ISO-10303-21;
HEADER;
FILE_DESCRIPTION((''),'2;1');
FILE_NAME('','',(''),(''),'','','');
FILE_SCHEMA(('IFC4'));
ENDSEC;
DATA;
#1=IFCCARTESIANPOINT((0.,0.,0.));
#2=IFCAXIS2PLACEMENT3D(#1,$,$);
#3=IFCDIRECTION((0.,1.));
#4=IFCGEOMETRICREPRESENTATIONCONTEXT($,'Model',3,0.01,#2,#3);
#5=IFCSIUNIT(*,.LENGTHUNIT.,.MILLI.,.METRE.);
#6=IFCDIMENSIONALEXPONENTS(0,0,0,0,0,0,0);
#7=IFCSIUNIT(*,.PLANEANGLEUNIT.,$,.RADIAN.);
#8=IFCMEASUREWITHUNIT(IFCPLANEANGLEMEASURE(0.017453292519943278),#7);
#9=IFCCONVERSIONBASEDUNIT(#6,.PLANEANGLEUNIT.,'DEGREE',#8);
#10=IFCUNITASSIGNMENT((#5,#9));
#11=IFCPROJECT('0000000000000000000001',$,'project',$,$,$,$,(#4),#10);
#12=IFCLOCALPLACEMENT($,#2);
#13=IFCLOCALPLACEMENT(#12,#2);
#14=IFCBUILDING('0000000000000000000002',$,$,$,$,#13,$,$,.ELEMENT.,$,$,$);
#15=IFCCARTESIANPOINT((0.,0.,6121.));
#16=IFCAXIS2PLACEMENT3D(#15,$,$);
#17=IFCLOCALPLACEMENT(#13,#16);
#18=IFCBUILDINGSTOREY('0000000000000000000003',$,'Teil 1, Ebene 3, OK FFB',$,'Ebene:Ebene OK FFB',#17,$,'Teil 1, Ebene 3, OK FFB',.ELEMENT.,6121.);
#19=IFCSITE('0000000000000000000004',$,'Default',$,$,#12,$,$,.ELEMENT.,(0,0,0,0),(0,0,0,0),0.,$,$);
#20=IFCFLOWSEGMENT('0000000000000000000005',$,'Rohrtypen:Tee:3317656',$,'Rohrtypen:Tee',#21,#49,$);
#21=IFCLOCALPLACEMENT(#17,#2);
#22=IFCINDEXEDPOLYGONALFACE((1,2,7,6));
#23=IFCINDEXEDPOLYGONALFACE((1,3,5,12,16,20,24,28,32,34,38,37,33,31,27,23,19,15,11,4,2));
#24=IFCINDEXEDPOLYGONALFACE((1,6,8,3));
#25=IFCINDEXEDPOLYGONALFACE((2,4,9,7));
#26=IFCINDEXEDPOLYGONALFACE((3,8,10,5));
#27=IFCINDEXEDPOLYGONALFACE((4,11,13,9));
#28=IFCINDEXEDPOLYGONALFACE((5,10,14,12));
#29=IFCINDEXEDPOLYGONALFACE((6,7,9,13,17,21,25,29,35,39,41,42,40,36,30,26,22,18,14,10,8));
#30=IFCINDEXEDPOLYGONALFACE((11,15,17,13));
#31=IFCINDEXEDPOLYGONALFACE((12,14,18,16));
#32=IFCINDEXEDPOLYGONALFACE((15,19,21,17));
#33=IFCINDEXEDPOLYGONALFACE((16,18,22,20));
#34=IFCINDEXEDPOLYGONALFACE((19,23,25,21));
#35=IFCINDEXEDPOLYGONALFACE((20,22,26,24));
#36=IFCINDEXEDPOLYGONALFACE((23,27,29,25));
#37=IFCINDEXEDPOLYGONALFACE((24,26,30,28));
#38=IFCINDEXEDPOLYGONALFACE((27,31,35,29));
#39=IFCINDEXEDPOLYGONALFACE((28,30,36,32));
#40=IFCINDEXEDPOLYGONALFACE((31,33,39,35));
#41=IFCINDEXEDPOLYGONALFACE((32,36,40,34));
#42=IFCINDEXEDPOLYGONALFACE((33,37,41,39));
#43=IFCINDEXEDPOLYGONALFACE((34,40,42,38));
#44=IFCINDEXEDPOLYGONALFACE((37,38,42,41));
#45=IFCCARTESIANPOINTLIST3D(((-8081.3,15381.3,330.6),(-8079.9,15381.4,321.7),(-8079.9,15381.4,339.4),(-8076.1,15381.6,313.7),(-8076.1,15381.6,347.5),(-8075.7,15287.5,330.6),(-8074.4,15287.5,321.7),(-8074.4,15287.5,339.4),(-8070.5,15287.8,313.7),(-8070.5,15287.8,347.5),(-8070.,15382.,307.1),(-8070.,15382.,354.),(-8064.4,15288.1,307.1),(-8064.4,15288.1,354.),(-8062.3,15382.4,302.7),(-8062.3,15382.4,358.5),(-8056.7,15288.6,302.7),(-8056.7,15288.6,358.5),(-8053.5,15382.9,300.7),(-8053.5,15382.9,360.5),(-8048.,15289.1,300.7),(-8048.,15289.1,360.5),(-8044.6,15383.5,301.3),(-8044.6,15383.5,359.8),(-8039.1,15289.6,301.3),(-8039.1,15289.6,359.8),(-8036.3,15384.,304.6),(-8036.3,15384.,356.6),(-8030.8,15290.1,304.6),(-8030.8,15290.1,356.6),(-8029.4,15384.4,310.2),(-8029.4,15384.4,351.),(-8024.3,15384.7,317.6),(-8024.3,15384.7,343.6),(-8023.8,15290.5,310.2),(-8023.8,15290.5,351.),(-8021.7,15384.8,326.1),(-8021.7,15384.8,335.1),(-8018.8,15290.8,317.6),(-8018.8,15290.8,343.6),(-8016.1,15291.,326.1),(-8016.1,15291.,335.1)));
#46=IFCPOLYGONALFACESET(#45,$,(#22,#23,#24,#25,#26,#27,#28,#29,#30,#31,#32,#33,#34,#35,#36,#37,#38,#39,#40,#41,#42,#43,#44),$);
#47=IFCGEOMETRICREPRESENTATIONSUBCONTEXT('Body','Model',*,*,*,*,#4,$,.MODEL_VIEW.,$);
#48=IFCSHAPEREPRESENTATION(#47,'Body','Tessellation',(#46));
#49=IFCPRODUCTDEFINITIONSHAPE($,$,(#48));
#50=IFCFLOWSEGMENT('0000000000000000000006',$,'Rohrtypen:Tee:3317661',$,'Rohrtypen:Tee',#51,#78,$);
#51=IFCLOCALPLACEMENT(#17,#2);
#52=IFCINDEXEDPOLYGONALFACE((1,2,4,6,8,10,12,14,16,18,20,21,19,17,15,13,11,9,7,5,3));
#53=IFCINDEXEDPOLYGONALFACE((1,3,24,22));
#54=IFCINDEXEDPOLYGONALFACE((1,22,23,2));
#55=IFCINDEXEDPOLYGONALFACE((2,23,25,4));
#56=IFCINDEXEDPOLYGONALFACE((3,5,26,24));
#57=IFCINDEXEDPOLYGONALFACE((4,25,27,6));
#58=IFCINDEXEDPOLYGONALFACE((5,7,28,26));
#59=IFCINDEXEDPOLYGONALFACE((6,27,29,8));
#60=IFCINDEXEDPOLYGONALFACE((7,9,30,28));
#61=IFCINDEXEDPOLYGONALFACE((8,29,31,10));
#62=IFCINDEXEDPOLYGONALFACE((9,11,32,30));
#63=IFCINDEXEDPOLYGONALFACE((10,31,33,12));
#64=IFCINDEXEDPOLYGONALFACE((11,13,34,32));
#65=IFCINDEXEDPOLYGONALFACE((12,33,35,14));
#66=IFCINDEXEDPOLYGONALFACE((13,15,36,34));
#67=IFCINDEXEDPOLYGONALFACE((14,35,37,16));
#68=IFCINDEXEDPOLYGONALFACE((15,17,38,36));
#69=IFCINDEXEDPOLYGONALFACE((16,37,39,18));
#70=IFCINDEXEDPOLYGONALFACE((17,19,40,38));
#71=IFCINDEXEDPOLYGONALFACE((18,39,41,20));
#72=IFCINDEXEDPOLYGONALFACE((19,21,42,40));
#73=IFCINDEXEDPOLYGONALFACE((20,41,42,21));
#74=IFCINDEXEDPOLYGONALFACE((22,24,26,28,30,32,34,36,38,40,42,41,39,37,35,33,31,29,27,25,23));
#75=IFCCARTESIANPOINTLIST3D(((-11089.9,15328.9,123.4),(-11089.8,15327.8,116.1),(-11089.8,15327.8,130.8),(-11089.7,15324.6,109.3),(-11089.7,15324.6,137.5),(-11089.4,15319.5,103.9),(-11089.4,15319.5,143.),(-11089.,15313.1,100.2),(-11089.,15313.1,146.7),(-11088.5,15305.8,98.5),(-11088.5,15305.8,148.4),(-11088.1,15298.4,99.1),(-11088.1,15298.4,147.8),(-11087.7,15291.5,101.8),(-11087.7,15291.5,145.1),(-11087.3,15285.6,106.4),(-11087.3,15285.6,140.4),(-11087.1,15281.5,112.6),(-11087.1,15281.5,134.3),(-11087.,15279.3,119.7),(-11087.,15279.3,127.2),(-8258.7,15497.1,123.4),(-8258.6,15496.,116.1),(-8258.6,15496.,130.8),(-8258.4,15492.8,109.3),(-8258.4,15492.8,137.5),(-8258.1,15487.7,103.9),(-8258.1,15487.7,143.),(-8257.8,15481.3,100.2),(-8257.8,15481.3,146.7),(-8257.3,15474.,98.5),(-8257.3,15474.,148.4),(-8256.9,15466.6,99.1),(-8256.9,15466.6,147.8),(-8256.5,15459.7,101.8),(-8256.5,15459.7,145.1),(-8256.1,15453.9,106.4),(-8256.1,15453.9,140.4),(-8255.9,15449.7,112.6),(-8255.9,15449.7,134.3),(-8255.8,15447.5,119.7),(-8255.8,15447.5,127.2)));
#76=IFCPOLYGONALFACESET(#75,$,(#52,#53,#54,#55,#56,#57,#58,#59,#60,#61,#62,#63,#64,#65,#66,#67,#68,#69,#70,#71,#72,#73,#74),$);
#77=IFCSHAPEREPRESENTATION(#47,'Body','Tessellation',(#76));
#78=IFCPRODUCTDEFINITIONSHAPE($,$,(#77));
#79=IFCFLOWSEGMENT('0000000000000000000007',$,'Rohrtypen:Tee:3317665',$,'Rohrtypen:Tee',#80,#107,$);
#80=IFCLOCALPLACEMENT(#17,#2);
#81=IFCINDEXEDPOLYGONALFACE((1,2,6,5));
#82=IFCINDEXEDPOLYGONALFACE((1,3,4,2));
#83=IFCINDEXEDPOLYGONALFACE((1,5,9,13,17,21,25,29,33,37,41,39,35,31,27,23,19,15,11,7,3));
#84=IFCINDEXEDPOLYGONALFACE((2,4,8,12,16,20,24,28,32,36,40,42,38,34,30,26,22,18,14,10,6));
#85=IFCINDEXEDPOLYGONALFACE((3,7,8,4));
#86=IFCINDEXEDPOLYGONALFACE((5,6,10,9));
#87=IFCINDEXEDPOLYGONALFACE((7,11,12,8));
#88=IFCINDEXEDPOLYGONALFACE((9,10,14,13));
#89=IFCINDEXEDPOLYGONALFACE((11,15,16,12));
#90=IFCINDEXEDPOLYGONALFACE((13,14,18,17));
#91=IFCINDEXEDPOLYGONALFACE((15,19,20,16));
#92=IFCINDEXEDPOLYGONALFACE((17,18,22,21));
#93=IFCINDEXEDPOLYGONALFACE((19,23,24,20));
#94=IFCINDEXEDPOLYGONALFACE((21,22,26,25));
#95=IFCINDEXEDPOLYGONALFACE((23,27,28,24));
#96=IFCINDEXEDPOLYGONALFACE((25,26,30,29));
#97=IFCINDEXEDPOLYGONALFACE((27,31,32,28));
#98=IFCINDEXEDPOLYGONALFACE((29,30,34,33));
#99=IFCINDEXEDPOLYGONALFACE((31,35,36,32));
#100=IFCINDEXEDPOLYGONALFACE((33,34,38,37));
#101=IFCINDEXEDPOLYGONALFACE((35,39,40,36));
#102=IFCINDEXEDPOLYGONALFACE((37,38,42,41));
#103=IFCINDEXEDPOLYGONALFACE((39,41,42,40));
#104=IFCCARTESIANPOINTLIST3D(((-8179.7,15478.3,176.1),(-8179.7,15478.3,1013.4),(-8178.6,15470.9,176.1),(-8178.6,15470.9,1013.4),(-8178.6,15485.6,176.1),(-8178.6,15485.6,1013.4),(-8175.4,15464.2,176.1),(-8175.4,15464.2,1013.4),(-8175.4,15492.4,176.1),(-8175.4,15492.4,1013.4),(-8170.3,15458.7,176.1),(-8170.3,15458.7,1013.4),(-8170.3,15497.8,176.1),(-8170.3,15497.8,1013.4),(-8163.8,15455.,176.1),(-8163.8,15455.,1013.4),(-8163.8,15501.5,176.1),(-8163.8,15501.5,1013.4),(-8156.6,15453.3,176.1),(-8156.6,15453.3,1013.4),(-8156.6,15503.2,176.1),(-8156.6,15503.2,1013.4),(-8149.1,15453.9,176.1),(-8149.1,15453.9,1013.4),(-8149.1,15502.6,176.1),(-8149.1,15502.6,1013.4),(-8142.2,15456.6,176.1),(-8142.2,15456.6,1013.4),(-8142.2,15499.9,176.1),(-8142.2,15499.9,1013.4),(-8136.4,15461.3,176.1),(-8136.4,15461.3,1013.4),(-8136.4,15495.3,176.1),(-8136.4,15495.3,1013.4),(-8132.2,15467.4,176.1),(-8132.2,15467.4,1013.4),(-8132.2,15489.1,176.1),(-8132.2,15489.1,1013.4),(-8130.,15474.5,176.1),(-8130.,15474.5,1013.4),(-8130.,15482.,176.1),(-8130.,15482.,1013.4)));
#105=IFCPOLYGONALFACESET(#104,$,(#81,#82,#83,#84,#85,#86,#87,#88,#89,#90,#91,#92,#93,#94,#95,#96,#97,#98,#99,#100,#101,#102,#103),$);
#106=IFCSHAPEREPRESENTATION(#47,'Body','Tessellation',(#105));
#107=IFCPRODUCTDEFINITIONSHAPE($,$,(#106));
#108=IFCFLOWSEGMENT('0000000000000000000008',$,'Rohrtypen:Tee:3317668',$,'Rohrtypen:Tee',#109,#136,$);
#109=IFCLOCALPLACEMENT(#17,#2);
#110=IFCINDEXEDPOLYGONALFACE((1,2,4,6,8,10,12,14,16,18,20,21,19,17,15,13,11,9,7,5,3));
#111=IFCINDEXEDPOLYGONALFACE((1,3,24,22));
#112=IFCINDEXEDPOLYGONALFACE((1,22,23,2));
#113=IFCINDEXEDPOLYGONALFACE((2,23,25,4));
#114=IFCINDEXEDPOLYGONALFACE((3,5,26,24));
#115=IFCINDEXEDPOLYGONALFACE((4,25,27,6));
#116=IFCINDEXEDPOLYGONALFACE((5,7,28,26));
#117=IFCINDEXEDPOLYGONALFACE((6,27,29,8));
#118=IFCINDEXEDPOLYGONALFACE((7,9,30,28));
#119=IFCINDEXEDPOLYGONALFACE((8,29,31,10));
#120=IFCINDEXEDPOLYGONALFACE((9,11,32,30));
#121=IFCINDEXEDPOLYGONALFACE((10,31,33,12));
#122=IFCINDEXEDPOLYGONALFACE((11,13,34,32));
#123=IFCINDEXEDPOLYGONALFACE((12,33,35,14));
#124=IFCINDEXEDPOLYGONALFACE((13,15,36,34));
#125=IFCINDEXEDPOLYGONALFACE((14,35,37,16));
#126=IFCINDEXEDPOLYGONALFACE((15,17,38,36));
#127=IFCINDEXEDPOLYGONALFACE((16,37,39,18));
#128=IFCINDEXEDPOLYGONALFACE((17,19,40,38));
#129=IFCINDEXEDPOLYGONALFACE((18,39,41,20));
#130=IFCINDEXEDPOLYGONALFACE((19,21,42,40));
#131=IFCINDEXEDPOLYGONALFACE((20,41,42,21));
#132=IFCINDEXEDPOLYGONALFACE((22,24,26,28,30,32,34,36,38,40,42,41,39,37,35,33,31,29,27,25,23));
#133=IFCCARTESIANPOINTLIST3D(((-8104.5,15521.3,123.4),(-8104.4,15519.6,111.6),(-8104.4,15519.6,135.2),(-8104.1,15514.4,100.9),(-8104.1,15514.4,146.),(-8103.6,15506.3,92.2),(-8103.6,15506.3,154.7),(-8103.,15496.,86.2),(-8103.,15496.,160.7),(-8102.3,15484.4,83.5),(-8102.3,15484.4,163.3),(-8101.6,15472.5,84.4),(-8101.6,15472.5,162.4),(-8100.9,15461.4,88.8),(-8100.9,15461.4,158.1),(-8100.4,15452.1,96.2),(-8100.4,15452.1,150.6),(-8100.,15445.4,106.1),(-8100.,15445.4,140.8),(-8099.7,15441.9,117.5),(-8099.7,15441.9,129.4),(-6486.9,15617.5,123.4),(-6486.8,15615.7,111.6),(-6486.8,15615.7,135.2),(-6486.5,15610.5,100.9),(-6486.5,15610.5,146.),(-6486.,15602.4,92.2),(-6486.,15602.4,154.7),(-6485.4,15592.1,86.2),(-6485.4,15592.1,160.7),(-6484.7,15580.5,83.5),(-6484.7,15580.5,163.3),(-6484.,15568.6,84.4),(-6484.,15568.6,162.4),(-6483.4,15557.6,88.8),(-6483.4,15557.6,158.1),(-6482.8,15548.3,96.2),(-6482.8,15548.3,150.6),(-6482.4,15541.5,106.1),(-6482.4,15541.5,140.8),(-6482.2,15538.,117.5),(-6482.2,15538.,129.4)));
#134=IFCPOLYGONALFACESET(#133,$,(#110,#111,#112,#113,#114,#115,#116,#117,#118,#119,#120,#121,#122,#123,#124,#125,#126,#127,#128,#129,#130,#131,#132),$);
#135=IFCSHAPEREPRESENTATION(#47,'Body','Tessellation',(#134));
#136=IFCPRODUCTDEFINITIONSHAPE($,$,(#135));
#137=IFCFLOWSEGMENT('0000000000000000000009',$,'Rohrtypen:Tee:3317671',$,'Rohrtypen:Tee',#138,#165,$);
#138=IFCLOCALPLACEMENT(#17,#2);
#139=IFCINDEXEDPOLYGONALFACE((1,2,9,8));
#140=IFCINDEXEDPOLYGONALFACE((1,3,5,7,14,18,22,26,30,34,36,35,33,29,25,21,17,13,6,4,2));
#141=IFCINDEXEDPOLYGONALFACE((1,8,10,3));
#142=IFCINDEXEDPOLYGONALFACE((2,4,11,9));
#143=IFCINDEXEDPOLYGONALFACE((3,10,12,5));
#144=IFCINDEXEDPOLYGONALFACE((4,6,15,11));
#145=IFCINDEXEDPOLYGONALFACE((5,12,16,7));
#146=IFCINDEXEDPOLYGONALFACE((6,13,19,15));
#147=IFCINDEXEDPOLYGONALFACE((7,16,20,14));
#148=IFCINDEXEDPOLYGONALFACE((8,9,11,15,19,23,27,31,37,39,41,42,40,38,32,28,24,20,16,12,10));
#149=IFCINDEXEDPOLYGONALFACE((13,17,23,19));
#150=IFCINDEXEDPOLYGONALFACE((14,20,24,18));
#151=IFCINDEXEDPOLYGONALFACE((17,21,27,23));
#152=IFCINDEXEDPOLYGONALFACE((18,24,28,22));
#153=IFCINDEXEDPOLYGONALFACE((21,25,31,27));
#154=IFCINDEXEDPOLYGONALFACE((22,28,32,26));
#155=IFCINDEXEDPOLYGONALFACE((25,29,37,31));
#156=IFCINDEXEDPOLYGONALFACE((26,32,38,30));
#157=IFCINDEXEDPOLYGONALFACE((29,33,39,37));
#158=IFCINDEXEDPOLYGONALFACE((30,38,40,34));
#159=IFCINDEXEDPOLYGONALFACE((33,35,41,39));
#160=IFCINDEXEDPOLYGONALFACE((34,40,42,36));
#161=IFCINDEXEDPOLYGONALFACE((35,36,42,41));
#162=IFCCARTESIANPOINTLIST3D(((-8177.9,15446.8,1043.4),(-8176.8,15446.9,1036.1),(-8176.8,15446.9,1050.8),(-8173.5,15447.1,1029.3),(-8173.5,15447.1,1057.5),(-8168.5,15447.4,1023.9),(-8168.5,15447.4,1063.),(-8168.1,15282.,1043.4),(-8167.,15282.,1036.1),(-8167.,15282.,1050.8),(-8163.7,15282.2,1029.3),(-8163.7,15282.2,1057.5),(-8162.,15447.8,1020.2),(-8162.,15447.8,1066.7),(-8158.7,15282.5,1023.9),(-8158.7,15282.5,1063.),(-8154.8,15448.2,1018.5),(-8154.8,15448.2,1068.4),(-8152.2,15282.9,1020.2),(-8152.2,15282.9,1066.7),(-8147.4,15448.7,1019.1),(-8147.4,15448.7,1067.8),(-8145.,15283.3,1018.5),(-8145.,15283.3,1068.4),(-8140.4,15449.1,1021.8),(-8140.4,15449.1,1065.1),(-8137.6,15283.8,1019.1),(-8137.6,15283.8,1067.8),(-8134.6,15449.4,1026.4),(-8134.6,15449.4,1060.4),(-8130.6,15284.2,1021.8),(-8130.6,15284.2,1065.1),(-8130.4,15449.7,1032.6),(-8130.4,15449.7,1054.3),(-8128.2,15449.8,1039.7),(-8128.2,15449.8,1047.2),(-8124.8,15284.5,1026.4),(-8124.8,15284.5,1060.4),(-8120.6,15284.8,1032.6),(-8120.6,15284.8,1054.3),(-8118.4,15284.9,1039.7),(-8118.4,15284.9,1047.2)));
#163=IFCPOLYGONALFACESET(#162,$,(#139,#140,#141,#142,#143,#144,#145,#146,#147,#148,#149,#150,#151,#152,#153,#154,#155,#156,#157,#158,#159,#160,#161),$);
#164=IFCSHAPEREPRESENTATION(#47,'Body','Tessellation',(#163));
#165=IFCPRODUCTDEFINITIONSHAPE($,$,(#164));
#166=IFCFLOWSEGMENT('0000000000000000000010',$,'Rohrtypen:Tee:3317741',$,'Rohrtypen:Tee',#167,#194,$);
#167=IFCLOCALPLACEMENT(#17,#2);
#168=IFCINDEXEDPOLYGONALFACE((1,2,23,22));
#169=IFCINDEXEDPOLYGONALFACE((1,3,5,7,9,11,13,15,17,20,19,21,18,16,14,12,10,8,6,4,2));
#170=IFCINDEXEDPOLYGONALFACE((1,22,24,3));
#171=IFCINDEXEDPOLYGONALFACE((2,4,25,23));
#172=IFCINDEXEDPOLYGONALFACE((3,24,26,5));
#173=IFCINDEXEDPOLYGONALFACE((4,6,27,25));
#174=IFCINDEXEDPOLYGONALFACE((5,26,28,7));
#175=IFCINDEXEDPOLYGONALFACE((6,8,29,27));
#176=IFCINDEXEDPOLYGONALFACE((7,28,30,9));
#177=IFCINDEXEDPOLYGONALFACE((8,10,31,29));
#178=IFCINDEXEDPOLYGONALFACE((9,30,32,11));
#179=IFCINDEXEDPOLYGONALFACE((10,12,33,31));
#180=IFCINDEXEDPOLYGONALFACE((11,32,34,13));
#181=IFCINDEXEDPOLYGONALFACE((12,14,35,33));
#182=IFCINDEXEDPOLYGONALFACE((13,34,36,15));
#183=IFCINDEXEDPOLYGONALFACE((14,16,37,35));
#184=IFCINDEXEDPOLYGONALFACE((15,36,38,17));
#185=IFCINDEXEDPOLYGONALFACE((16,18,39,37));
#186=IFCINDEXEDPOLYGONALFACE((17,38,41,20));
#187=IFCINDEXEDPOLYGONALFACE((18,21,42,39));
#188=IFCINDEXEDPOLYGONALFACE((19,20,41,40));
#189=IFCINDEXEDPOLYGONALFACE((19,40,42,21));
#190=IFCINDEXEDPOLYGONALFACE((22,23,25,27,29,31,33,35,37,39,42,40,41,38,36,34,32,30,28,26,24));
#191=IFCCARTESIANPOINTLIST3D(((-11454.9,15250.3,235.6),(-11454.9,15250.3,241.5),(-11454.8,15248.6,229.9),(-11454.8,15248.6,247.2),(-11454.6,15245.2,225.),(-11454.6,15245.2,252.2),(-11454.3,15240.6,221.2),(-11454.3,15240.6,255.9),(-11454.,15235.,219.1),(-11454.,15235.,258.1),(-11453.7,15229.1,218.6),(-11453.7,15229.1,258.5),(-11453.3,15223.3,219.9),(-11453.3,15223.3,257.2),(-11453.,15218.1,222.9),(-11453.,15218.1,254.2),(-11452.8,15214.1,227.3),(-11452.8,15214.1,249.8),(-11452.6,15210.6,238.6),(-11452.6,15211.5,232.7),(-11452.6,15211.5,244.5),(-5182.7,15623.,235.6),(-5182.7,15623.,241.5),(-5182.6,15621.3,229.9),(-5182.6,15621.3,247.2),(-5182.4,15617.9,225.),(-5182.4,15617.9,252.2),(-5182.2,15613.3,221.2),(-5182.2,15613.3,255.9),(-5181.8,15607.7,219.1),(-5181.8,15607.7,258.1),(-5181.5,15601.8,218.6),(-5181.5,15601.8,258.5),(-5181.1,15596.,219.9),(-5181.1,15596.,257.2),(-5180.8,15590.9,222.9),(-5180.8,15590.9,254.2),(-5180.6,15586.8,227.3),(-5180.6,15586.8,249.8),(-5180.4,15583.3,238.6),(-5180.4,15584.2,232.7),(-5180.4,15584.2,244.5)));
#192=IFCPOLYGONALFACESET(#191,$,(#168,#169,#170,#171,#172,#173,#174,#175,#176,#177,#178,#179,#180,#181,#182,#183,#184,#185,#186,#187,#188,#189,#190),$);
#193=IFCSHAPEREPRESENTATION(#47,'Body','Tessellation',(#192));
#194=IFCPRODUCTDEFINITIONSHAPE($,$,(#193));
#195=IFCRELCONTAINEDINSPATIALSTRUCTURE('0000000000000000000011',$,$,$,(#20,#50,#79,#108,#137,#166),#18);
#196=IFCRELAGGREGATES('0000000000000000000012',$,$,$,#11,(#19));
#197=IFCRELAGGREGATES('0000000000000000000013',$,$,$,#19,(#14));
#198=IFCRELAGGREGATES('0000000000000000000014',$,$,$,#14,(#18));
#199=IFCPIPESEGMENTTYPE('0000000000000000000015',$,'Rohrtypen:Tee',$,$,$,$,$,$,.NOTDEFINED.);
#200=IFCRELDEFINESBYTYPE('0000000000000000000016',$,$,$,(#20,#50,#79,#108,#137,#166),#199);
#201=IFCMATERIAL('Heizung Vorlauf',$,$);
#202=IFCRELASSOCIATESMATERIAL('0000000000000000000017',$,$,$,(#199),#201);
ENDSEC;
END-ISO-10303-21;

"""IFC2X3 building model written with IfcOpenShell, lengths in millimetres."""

from ifc_helpers import new_model, entity, si_unit, converted_unit, direction, frame, frame_2d, origin, origin_2d_with_axis, place, context, subcontext, project, spatial, circle, extrude, material, type_object, element, save


model = new_model("IFC2X3")

# Units and contexts
model_context = context("Model", 3, precision=0.01, world=origin(), true_north=direction((0.0, 1.0)))
body_context = subcontext(model_context, "Body", "Model", "MODEL_VIEW")
ifc_project = project(units=[si_unit("LENGTHUNIT", "METRE", prefix="MILLI"), converted_unit("PLANEANGLEUNIT", "DEGREE", entity("IfcPlaneAngleMeasure", 0.017453292519943278), si_unit("PLANEANGLEUNIT", "RADIAN"), dimensions=[0, 0, 0, 0, 0, 0, 0])], contexts=[model_context])

# Site, building, storey
site_placement = place(None, origin())
site = spatial("IfcSite", under=ifc_project, at=site_placement, Name="Default", CompositionType="ELEMENT", RefLatitude=(0, 0, 0, 0), RefLongitude=(0, 0, 0, 0), RefElevation=0.0)
building_placement = place(site_placement, origin())
building = spatial("IfcBuilding", under=site, at=building_placement, CompositionType="ELEMENT")
storey_placement = place(building_placement, frame((0.0, 0.0, 6121.0)))
storey = spatial("IfcBuildingStorey", under=building, at=storey_placement, Name="Teil 1, Ebene 3, OK FFB", ObjectType="Ebene:Ebene OK FFB", LongName="Teil 1, Ebene 3, OK FFB", CompositionType="ELEMENT", Elevation=6121.0)

# Flow segments
ifc_material = material(Name="Heizung Vorlauf")
pipe_segment_type = type_object("IfcPipeSegmentType", Name="Rohrtypen:Tee", PredefinedType="NOTDEFINED", material=ifc_material)
flow_segment_1_placement = place(storey_placement, origin())
element("IfcFlowSegment", 1, at=flow_segment_1_placement, inside=storey, type_object=pipe_segment_type, Name="Rohrtypen:Tee:3317656", ObjectType="Rohrtypen:Tee", context=body_context, shape_type="SweptSolid", body=[
    extrude(circle(Radius=30.0, at=origin_2d_with_axis()), frame((-8045.7, 15289.2, 330.6), z_axis=(-0.059319, 0.998239, 0.0), x_axis=(-0.998239, -0.059319, 0.0)), (0.0, 0.0, 1.0), 94.0),
])
flow_segment_2_placement = place(storey_placement, origin())
element("IfcFlowSegment", 2, at=flow_segment_2_placement, inside=storey, type_object=pipe_segment_type, Name="Rohrtypen:Tee:3317661", ObjectType="Rohrtypen:Tee", context=body_context, shape_type="SweptSolid", body=[
    extrude(circle(Radius=25.0, at=frame_2d((0.0, 0.0), x_axis=(1.0, 0.0))), frame((-11088.4, 15303.9, 123.4), z_axis=(0.998239, 0.059319, 0.0), x_axis=(-0.059319, 0.998239, 0.0)), (0.0, 0.0, 1.0), 2836.2),
])
flow_segment_3_placement = place(storey_placement, origin())
element("IfcFlowSegment", 3, at=flow_segment_3_placement, inside=storey, type_object=pipe_segment_type, Name="Rohrtypen:Tee:3317665", ObjectType="Rohrtypen:Tee", context=body_context, shape_type="SweptSolid", body=[
    extrude(circle(Radius=25.0, at=frame_2d((0.0, 0.0), x_axis=(1.0, 0.0))), frame((-8154.7, 15478.3, 176.1), z_axis=(0.0, 0.0, 1.0), x_axis=(-1.0, 0.0, 0.0)), (0.0, 0.0, 1.0), 837.3),
])
flow_segment_4_placement = place(storey_placement, origin())
element("IfcFlowSegment", 4, at=flow_segment_4_placement, inside=storey, type_object=pipe_segment_type, Name="Rohrtypen:Tee:3317668", ObjectType="Rohrtypen:Tee", context=body_context, shape_type="SweptSolid", body=[
    extrude(circle(Radius=40.0, at=origin_2d_with_axis()), frame((-8102.1, 15481.4, 123.4), z_axis=(0.998239, 0.059319, 0.0), x_axis=(-0.059319, 0.998239, 0.0)), (0.0, 0.0, 1.0), 1620.4),
])
flow_segment_5_placement = place(storey_placement, origin())
element("IfcFlowSegment", 5, at=flow_segment_5_placement, inside=storey, type_object=pipe_segment_type, Name="Rohrtypen:Tee:3317671", ObjectType="Rohrtypen:Tee", context=body_context, shape_type="SweptSolid", body=[
    extrude(circle(Radius=25.0, at=frame_2d((0.0, 0.0), x_axis=(1.0, 0.0))), frame((-8143.1, 15283.5, 1043.4), z_axis=(-0.059319, 0.998239, 0.0), x_axis=(-0.998239, -0.059319, 0.0)), (0.0, 0.0, 1.0), 165.2),
])
flow_segment_6_placement = place(storey_placement, origin())
element("IfcFlowSegment", 6, at=flow_segment_6_placement, inside=storey, type_object=pipe_segment_type, Name="Rohrtypen:Tee:3317741", ObjectType="Rohrtypen:Tee", context=body_context, shape_type="SweptSolid", body=[
    extrude(circle(Radius=20.0, at=origin_2d_with_axis()), frame((-11453.7, 15230.6, 238.6), z_axis=(0.998239, 0.059319, 0.0), x_axis=(0.059319, -0.998239, 0.0)), (0.0, 0.0, 1.0), 6283.2),
])

save(model, "model.ifc")
